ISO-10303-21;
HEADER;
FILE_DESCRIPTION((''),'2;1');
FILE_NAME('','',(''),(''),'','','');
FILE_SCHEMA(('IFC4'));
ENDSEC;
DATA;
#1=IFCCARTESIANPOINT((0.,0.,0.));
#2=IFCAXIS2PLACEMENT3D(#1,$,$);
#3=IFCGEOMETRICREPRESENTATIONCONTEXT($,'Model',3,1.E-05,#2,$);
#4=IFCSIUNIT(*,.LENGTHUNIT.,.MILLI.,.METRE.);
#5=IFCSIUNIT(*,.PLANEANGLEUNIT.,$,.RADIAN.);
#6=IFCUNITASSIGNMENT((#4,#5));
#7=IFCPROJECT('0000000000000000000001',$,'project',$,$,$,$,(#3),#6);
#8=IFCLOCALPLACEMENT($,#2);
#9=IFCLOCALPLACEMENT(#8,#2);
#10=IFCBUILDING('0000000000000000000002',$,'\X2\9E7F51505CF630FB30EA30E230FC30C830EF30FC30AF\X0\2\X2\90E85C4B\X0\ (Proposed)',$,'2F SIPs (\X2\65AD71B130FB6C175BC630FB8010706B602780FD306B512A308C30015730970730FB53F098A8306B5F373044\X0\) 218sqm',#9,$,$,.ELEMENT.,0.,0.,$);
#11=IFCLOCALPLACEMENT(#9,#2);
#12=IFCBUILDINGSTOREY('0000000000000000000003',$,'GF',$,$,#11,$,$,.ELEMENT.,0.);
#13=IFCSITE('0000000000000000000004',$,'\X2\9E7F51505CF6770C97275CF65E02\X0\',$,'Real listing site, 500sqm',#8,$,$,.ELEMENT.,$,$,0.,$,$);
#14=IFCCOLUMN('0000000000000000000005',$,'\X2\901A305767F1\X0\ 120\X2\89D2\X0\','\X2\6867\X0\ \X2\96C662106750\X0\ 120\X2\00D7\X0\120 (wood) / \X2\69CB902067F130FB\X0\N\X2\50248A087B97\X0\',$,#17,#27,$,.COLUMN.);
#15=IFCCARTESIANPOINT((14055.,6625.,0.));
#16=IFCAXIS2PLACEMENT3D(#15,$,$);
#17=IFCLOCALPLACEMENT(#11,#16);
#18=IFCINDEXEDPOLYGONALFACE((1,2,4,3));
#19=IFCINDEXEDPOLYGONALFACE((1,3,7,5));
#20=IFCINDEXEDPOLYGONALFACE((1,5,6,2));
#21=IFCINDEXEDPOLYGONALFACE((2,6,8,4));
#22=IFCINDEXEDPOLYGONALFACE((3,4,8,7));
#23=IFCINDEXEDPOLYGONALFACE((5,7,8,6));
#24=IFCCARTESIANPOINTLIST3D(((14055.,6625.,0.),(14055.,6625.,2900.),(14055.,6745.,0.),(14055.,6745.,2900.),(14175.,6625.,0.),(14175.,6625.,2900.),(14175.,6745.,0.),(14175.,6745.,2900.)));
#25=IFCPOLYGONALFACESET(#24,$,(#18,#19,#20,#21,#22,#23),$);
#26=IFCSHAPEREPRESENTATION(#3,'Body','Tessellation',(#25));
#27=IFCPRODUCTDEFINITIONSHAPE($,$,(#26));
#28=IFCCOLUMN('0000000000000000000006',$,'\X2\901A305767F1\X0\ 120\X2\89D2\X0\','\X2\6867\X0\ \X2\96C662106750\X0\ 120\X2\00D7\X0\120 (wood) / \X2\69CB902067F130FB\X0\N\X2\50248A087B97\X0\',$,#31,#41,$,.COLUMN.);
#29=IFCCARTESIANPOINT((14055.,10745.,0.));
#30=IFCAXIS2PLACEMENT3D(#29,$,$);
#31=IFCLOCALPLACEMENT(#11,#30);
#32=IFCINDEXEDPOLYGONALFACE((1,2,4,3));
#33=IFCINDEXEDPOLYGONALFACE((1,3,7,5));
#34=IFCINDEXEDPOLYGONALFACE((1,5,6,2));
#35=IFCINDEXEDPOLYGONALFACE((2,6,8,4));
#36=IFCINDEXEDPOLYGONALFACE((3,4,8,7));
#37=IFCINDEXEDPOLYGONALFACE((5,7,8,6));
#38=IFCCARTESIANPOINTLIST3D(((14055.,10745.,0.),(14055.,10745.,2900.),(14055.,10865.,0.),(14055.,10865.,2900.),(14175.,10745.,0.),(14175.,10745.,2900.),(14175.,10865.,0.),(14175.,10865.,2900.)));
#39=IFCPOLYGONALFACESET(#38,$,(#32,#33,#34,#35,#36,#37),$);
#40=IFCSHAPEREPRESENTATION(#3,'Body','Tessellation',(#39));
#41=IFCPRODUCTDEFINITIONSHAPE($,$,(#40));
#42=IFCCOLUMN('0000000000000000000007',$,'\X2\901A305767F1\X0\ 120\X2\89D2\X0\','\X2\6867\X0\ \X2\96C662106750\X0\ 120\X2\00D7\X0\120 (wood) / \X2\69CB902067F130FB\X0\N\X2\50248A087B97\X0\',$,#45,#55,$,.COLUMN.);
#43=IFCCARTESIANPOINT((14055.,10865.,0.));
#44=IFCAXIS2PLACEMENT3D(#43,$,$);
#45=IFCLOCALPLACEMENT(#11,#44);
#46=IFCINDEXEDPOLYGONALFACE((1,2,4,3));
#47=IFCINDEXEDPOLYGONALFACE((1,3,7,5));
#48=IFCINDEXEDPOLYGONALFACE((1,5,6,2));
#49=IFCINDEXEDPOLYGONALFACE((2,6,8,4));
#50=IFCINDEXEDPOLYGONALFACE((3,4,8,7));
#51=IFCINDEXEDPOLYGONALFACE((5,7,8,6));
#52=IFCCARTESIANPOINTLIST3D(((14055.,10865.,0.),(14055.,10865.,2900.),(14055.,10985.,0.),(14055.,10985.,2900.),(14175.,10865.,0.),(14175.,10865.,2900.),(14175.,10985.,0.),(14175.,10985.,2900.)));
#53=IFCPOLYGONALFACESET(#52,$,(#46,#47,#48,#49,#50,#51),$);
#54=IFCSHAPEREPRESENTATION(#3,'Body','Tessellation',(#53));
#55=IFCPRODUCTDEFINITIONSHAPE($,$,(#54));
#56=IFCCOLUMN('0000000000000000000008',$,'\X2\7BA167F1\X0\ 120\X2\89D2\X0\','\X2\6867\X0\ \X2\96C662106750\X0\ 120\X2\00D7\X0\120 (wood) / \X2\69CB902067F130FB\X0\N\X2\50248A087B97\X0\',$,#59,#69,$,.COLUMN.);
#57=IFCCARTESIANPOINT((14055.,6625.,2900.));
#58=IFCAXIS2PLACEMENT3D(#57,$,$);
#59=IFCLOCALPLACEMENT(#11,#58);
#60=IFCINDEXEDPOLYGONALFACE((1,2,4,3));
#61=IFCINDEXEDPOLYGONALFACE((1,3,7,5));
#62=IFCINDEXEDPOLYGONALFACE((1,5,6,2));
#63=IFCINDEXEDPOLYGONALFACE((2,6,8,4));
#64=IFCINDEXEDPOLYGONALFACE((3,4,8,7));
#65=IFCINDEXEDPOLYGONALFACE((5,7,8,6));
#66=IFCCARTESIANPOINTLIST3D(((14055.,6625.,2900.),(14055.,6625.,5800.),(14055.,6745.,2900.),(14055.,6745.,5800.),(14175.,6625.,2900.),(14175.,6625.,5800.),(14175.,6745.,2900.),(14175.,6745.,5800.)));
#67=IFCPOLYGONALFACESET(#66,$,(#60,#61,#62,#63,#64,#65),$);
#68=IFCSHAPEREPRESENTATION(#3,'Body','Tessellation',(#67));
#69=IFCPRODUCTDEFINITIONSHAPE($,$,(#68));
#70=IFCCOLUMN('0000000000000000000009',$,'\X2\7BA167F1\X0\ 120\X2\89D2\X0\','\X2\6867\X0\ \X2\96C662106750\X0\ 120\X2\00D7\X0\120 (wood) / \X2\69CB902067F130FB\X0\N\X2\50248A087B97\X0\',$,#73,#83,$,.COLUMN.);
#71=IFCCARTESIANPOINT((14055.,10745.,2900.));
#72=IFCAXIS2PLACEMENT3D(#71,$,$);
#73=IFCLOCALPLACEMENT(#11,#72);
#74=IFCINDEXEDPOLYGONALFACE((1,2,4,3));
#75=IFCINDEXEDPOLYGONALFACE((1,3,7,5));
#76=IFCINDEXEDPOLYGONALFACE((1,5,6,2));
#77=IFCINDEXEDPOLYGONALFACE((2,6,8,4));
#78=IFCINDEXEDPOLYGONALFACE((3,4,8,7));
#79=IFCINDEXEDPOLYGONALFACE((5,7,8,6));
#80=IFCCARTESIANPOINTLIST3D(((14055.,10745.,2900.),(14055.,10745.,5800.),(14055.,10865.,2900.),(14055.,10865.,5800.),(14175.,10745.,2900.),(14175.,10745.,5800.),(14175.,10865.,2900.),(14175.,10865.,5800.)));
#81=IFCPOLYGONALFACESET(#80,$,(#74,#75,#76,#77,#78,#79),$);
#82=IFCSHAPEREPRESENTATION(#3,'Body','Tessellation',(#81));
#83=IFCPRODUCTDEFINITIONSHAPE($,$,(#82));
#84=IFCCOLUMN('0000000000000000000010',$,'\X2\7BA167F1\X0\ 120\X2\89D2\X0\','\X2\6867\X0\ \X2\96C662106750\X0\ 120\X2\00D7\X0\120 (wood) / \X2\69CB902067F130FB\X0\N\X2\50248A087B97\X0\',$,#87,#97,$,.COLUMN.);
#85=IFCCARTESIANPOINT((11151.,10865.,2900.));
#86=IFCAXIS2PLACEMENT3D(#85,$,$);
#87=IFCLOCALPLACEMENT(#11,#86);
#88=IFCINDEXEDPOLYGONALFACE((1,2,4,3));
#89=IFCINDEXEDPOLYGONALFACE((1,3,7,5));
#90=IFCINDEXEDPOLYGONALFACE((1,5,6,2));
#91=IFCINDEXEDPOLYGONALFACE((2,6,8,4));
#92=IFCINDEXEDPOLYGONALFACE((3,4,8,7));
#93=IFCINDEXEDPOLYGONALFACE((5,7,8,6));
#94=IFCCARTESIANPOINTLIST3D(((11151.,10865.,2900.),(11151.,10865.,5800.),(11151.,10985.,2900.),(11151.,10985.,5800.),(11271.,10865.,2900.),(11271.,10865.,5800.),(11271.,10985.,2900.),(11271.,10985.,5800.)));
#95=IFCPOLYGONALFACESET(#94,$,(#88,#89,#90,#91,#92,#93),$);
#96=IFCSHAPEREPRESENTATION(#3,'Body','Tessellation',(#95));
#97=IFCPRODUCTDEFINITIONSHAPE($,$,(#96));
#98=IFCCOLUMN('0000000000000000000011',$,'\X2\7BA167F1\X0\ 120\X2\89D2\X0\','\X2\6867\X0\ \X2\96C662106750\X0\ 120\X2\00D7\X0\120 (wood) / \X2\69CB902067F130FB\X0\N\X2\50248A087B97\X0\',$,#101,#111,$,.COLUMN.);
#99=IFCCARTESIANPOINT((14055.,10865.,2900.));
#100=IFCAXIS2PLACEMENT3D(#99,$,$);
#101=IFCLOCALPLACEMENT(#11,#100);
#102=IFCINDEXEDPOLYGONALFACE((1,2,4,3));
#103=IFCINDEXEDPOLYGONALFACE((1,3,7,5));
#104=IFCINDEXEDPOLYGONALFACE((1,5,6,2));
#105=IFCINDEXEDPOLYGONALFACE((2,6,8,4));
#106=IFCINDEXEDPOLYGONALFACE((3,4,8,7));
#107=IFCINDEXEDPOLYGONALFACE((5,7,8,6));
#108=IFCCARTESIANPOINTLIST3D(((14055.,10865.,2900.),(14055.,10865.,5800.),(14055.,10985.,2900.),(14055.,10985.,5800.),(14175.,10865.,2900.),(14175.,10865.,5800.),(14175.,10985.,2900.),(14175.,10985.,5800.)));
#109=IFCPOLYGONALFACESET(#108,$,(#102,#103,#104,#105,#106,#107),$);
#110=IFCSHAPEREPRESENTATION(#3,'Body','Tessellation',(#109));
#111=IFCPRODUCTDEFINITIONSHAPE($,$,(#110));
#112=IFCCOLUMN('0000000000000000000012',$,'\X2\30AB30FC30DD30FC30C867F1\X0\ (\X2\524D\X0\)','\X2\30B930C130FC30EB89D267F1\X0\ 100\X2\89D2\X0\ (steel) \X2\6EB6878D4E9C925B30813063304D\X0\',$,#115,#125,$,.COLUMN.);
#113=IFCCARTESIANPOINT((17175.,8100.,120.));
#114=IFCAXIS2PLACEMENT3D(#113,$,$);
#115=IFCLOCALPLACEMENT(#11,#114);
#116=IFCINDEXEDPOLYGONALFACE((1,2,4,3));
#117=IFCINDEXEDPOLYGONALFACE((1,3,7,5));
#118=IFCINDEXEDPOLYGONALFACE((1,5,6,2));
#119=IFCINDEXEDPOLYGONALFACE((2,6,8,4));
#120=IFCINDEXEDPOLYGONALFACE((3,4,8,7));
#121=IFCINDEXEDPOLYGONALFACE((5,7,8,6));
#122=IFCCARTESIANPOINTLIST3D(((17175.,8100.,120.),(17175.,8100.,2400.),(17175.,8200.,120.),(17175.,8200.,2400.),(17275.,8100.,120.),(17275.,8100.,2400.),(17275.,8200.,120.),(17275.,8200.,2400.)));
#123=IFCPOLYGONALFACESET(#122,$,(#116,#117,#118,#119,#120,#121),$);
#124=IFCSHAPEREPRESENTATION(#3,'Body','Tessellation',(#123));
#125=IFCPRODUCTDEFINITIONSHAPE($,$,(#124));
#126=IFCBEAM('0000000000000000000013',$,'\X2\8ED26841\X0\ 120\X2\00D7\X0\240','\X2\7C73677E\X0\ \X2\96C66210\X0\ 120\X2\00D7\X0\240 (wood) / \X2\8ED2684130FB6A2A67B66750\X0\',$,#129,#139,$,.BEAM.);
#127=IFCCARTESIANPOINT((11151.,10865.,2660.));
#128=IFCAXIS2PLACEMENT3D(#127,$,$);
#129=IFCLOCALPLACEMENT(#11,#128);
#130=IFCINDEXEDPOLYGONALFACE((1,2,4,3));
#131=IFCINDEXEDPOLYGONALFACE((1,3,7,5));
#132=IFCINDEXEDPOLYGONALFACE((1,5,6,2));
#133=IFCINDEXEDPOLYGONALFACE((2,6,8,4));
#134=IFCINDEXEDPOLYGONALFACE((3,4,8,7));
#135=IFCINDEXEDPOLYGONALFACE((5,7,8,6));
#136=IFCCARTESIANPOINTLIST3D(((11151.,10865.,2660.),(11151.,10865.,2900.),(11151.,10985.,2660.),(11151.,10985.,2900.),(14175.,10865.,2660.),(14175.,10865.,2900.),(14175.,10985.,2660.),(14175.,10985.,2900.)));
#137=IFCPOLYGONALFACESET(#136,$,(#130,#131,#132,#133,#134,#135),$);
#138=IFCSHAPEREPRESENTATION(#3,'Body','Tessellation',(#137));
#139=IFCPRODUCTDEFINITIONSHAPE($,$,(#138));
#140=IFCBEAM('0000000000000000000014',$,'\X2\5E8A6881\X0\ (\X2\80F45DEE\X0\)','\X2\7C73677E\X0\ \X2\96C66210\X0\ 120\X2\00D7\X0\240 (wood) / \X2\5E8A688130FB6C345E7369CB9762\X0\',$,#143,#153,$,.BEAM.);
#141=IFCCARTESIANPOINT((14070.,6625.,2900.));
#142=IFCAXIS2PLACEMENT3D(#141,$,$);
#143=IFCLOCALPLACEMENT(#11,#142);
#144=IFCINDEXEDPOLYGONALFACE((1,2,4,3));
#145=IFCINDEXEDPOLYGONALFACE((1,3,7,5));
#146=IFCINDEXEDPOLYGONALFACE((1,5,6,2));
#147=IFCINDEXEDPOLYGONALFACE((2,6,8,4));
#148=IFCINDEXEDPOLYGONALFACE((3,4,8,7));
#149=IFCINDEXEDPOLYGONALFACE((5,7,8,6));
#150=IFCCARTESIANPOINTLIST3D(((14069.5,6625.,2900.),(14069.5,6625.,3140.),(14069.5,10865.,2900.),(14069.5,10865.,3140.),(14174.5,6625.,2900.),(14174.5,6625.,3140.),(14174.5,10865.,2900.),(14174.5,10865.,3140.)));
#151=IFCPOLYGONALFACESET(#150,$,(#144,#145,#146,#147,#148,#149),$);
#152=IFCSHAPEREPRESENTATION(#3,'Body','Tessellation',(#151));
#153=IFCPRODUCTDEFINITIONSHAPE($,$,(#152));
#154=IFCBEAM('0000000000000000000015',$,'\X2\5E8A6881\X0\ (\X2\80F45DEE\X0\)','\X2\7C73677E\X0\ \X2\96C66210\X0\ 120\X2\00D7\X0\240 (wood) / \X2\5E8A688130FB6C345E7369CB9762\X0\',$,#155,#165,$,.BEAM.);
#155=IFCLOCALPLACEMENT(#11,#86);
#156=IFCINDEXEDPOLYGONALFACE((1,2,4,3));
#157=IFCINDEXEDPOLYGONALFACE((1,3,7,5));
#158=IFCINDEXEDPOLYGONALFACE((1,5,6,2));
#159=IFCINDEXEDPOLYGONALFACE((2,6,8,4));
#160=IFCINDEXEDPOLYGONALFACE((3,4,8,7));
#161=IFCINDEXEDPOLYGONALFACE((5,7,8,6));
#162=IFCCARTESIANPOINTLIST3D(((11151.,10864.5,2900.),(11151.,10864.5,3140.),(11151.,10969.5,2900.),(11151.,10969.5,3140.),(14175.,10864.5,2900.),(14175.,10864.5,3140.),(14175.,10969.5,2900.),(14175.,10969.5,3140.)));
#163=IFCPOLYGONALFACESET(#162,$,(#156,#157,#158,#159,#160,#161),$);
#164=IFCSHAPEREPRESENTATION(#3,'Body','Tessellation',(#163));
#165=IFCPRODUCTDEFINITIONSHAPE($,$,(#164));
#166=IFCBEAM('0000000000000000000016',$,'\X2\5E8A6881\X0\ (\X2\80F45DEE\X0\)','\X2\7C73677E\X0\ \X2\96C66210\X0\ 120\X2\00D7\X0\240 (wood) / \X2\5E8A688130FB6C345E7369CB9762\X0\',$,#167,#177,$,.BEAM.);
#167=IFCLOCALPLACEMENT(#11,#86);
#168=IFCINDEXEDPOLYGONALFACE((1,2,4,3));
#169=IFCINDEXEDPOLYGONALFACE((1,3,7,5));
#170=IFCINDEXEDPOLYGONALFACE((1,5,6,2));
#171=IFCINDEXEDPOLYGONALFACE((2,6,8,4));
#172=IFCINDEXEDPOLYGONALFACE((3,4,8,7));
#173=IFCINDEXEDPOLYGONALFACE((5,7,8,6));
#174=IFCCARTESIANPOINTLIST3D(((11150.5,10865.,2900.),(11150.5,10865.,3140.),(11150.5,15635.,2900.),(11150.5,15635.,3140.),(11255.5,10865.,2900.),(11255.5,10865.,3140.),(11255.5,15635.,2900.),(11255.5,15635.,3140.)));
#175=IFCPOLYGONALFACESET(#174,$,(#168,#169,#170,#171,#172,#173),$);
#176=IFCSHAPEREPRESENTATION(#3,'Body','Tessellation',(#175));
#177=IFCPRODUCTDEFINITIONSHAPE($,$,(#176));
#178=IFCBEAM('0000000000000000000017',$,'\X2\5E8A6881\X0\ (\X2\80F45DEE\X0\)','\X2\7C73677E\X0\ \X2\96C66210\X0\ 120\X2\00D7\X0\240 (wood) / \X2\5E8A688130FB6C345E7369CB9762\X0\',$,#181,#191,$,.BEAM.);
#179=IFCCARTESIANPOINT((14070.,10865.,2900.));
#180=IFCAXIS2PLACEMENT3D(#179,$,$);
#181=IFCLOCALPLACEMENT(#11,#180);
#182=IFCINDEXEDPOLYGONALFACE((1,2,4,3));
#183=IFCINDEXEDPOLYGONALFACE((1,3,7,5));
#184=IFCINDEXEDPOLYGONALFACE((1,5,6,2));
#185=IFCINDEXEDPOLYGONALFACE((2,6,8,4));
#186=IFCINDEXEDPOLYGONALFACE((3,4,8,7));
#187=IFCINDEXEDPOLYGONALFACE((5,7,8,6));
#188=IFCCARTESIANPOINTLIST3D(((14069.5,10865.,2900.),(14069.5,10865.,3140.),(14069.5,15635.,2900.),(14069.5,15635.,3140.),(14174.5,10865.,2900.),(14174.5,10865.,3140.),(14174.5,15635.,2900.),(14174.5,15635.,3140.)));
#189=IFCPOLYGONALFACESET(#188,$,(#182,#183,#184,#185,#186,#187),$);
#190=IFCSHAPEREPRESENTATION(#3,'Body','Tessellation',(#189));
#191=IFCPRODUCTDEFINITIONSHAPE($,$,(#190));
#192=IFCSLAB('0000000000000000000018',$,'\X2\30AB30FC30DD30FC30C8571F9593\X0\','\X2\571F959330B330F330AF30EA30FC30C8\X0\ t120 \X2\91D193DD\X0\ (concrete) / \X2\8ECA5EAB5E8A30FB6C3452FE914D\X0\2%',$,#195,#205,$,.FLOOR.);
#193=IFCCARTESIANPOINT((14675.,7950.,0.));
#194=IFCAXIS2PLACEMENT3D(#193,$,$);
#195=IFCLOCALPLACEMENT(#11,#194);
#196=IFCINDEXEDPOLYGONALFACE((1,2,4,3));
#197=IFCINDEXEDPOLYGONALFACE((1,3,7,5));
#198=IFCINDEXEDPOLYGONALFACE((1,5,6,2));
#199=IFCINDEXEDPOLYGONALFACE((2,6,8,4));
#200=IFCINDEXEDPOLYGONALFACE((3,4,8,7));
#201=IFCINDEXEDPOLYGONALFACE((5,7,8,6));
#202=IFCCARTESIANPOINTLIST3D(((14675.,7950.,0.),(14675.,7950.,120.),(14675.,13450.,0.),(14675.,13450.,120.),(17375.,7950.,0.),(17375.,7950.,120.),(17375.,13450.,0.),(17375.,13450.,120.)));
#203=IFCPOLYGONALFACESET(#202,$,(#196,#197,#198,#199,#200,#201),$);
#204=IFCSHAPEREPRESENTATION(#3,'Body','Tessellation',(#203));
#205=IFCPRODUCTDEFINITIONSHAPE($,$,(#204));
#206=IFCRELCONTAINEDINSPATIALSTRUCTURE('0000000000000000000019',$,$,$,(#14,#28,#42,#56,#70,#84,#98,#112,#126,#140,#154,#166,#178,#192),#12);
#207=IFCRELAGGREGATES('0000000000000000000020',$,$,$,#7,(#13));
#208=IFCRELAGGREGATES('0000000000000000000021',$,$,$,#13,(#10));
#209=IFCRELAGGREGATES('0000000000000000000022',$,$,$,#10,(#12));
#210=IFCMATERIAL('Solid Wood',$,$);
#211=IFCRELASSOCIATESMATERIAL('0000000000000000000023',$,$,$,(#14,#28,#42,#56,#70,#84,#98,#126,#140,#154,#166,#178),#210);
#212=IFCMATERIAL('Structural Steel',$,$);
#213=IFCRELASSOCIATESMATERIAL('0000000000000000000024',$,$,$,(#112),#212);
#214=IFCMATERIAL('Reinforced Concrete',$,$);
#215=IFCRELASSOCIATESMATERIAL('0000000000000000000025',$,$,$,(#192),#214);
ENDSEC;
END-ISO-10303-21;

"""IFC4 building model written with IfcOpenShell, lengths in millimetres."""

from ifc_helpers import new_model, si_unit, frame, frame_2d, origin, place, context, project, spatial, rectangle, extrude, material, element, save


model = new_model("IFC4")

# Units and contexts
model_context = context("Model", 3, precision=1e-05, world=origin())
ifc_project = project(units=[si_unit("LENGTHUNIT", "METRE", prefix="MILLI"), si_unit("PLANEANGLEUNIT", "RADIAN")], contexts=[model_context])

# Site, building, storey
site_placement = place(None, origin())
site = spatial("IfcSite", under=ifc_project, at=site_placement, Name="鹿児島県霧島市", ObjectType="Real listing site, 500sqm", CompositionType="ELEMENT", RefElevation=0.0)
building_placement = place(site_placement, origin())
building = spatial("IfcBuilding", under=site, at=building_placement, Name="鹿児島・リモートワーク2部屋 (Proposed)", ObjectType="2F SIPs (断熱・気密・耐火性能に優れ、地震・台風に強い) 218sqm", CompositionType="ELEMENT", ElevationOfRefHeight=0.0, ElevationOfTerrain=0.0)
storey_placement = place(building_placement, origin())
storey = spatial("IfcBuildingStorey", under=building, at=storey_placement, Name="GF", CompositionType="ELEMENT", Elevation=0.0)

# Columns
ifc_material_1 = material(Name="Solid Wood")
column_1_placement = place(storey_placement, frame((14055.0, 6625.0, 0.0)))
element("IfcColumn", 1, at=column_1_placement, inside=storey, material=ifc_material_1, Name="通し柱 120角", Description="桧 集成材 120×120 (wood) / 構造柱・N値計算", PredefinedType="COLUMN", context=model_context, shape_type="SweptSolid", body=[
    extrude(rectangle(XDim=120.0, YDim=120.0, at=frame_2d((60.0, 60.0))), frame((14055.0, 6625.0, 0.0)), (0.0, 0.0, 1.0), 2900.0),
])
column_2_placement = place(storey_placement, frame((14055.0, 10745.0, 0.0)))
element("IfcColumn", 2, at=column_2_placement, inside=storey, material=ifc_material_1, Name="通し柱 120角", Description="桧 集成材 120×120 (wood) / 構造柱・N値計算", PredefinedType="COLUMN", context=model_context, shape_type="SweptSolid", body=[
    extrude(rectangle(XDim=120.0, YDim=120.0, at=frame_2d((60.0, 60.0))), frame((14055.0, 10745.0, 0.0)), (0.0, 0.0, 1.0), 2900.0),
])
column_3_placement = place(storey_placement, frame((14055.0, 10865.0, 0.0)))
element("IfcColumn", 3, at=column_3_placement, inside=storey, material=ifc_material_1, Name="通し柱 120角", Description="桧 集成材 120×120 (wood) / 構造柱・N値計算", PredefinedType="COLUMN", context=model_context, shape_type="SweptSolid", body=[
    extrude(rectangle(XDim=120.0, YDim=120.0, at=frame_2d((60.0, 60.0))), frame((14055.0, 10865.0, 0.0)), (0.0, 0.0, 1.0), 2900.0),
])
column_4_placement = place(storey_placement, frame((14055.0, 6625.0, 2900.0)))
element("IfcColumn", 4, at=column_4_placement, inside=storey, material=ifc_material_1, Name="管柱 120角", Description="桧 集成材 120×120 (wood) / 構造柱・N値計算", PredefinedType="COLUMN", context=model_context, shape_type="SweptSolid", body=[
    extrude(rectangle(XDim=120.0, YDim=120.0, at=frame_2d((60.0, 60.0))), frame((14055.0, 6625.0, 2900.0)), (0.0, 0.0, 1.0), 2900.0),
])
column_5_placement = place(storey_placement, frame((14055.0, 10745.0, 2900.0)))
element("IfcColumn", 5, at=column_5_placement, inside=storey, material=ifc_material_1, Name="管柱 120角", Description="桧 集成材 120×120 (wood) / 構造柱・N値計算", PredefinedType="COLUMN", context=model_context, shape_type="SweptSolid", body=[
    extrude(rectangle(XDim=120.0, YDim=120.0, at=frame_2d((60.0, 60.0))), frame((14055.0, 10745.0, 2900.0)), (0.0, 0.0, 1.0), 2900.0),
])
column_6_placement = place(storey_placement, frame((11151.0, 10865.0, 2900.0)))
element("IfcColumn", 6, at=column_6_placement, inside=storey, material=ifc_material_1, Name="管柱 120角", Description="桧 集成材 120×120 (wood) / 構造柱・N値計算", PredefinedType="COLUMN", context=model_context, shape_type="SweptSolid", body=[
    extrude(rectangle(XDim=120.0, YDim=120.0, at=frame_2d((60.0, 60.0))), frame((11151.0, 10865.0, 2900.0)), (0.0, 0.0, 1.0), 2900.0),
])
column_7_placement = place(storey_placement, frame((14055.0, 10865.0, 2900.0)))
element("IfcColumn", 7, at=column_7_placement, inside=storey, material=ifc_material_1, Name="管柱 120角", Description="桧 集成材 120×120 (wood) / 構造柱・N値計算", PredefinedType="COLUMN", context=model_context, shape_type="SweptSolid", body=[
    extrude(rectangle(XDim=120.0, YDim=120.0, at=frame_2d((60.0, 60.0))), frame((14055.0, 10865.0, 2900.0)), (0.0, 0.0, 1.0), 2900.0),
])
ifc_material_2 = material(Name="Structural Steel")
column_8_placement = place(storey_placement, frame((17175.0, 8100.0, 120.0)))
element("IfcColumn", 8, at=column_8_placement, inside=storey, material=ifc_material_2, Name="カーポート柱 (前)", Description="スチール角柱 100角 (steel) 溶融亜鉛めっき", PredefinedType="COLUMN", context=model_context, shape_type="SweptSolid", body=[
    extrude(rectangle(XDim=100.0, YDim=100.0, at=frame_2d((50.0, 50.0))), frame((17175.0, 8100.0, 120.0)), (0.0, 0.0, 1.0), 2280.0),
])

# Beams
beam_1_placement = place(storey_placement, frame((11151.0, 10865.0, 2660.0)))
element("IfcBeam", 9, at=beam_1_placement, inside=storey, material=ifc_material_1, Name="軒桁 120×240", Description="米松 集成 120×240 (wood) / 軒桁・横架材", PredefinedType="BEAM", context=model_context, shape_type="SweptSolid", body=[
    extrude(rectangle(XDim=3024.0, YDim=120.0, at=frame_2d((1512.0, 60.0))), frame((11151.0, 10865.0, 2660.0)), (0.0, 0.0, 1.0), 240.0),
])
beam_2_placement = place(storey_placement, frame((14070.0, 6625.0, 2900.0)))
element("IfcBeam", 10, at=beam_2_placement, inside=storey, material=ifc_material_1, Name="床梁 (胴差)", Description="米松 集成 120×240 (wood) / 床梁・水平構面", PredefinedType="BEAM", context=model_context, shape_type="SweptSolid", body=[
    extrude(rectangle(XDim=105.0, YDim=4240.0, at=frame_2d((52.0, 2120.0))), frame((14070.0, 6625.0, 2900.0)), (0.0, 0.0, 1.0), 240.0),
])
beam_3_placement = place(storey_placement, frame((11151.0, 10865.0, 2900.0)))
element("IfcBeam", 11, at=beam_3_placement, inside=storey, material=ifc_material_1, Name="床梁 (胴差)", Description="米松 集成 120×240 (wood) / 床梁・水平構面", PredefinedType="BEAM", context=model_context, shape_type="SweptSolid", body=[
    extrude(rectangle(XDim=3024.0, YDim=105.0, at=frame_2d((1512.0, 52.0))), frame((11151.0, 10865.0, 2900.0)), (0.0, 0.0, 1.0), 240.0),
])
beam_4_placement = place(storey_placement, frame((11151.0, 10865.0, 2900.0)))
element("IfcBeam", 12, at=beam_4_placement, inside=storey, material=ifc_material_1, Name="床梁 (胴差)", Description="米松 集成 120×240 (wood) / 床梁・水平構面", PredefinedType="BEAM", context=model_context, shape_type="SweptSolid", body=[
    extrude(rectangle(XDim=105.0, YDim=4770.0, at=frame_2d((52.0, 2385.0))), frame((11151.0, 10865.0, 2900.0)), (0.0, 0.0, 1.0), 240.0),
])
beam_5_placement = place(storey_placement, frame((14070.0, 10865.0, 2900.0)))
element("IfcBeam", 13, at=beam_5_placement, inside=storey, material=ifc_material_1, Name="床梁 (胴差)", Description="米松 集成 120×240 (wood) / 床梁・水平構面", PredefinedType="BEAM", context=model_context, shape_type="SweptSolid", body=[
    extrude(rectangle(XDim=105.0, YDim=4770.0, at=frame_2d((52.0, 2385.0))), frame((14070.0, 10865.0, 2900.0)), (0.0, 0.0, 1.0), 240.0),
])

# Slab
ifc_material_3 = material(Name="Reinforced Concrete")
slab_placement = place(storey_placement, frame((14675.0, 7950.0, 0.0)))
element("IfcSlab", 14, at=slab_placement, inside=storey, material=ifc_material_3, Name="カーポート土間", Description="土間コンクリート t120 金鏝 (concrete) / 車庫床・水勾配2%", PredefinedType="FLOOR", context=model_context, shape_type="SweptSolid", body=[
    extrude(rectangle(XDim=2700.0, YDim=5500.0, at=frame_2d((1350.0, 2750.0))), frame((14675.0, 7950.0, 0.0)), (0.0, 0.0, 1.0), 120.0),
])

save(model, "model.ifc")
